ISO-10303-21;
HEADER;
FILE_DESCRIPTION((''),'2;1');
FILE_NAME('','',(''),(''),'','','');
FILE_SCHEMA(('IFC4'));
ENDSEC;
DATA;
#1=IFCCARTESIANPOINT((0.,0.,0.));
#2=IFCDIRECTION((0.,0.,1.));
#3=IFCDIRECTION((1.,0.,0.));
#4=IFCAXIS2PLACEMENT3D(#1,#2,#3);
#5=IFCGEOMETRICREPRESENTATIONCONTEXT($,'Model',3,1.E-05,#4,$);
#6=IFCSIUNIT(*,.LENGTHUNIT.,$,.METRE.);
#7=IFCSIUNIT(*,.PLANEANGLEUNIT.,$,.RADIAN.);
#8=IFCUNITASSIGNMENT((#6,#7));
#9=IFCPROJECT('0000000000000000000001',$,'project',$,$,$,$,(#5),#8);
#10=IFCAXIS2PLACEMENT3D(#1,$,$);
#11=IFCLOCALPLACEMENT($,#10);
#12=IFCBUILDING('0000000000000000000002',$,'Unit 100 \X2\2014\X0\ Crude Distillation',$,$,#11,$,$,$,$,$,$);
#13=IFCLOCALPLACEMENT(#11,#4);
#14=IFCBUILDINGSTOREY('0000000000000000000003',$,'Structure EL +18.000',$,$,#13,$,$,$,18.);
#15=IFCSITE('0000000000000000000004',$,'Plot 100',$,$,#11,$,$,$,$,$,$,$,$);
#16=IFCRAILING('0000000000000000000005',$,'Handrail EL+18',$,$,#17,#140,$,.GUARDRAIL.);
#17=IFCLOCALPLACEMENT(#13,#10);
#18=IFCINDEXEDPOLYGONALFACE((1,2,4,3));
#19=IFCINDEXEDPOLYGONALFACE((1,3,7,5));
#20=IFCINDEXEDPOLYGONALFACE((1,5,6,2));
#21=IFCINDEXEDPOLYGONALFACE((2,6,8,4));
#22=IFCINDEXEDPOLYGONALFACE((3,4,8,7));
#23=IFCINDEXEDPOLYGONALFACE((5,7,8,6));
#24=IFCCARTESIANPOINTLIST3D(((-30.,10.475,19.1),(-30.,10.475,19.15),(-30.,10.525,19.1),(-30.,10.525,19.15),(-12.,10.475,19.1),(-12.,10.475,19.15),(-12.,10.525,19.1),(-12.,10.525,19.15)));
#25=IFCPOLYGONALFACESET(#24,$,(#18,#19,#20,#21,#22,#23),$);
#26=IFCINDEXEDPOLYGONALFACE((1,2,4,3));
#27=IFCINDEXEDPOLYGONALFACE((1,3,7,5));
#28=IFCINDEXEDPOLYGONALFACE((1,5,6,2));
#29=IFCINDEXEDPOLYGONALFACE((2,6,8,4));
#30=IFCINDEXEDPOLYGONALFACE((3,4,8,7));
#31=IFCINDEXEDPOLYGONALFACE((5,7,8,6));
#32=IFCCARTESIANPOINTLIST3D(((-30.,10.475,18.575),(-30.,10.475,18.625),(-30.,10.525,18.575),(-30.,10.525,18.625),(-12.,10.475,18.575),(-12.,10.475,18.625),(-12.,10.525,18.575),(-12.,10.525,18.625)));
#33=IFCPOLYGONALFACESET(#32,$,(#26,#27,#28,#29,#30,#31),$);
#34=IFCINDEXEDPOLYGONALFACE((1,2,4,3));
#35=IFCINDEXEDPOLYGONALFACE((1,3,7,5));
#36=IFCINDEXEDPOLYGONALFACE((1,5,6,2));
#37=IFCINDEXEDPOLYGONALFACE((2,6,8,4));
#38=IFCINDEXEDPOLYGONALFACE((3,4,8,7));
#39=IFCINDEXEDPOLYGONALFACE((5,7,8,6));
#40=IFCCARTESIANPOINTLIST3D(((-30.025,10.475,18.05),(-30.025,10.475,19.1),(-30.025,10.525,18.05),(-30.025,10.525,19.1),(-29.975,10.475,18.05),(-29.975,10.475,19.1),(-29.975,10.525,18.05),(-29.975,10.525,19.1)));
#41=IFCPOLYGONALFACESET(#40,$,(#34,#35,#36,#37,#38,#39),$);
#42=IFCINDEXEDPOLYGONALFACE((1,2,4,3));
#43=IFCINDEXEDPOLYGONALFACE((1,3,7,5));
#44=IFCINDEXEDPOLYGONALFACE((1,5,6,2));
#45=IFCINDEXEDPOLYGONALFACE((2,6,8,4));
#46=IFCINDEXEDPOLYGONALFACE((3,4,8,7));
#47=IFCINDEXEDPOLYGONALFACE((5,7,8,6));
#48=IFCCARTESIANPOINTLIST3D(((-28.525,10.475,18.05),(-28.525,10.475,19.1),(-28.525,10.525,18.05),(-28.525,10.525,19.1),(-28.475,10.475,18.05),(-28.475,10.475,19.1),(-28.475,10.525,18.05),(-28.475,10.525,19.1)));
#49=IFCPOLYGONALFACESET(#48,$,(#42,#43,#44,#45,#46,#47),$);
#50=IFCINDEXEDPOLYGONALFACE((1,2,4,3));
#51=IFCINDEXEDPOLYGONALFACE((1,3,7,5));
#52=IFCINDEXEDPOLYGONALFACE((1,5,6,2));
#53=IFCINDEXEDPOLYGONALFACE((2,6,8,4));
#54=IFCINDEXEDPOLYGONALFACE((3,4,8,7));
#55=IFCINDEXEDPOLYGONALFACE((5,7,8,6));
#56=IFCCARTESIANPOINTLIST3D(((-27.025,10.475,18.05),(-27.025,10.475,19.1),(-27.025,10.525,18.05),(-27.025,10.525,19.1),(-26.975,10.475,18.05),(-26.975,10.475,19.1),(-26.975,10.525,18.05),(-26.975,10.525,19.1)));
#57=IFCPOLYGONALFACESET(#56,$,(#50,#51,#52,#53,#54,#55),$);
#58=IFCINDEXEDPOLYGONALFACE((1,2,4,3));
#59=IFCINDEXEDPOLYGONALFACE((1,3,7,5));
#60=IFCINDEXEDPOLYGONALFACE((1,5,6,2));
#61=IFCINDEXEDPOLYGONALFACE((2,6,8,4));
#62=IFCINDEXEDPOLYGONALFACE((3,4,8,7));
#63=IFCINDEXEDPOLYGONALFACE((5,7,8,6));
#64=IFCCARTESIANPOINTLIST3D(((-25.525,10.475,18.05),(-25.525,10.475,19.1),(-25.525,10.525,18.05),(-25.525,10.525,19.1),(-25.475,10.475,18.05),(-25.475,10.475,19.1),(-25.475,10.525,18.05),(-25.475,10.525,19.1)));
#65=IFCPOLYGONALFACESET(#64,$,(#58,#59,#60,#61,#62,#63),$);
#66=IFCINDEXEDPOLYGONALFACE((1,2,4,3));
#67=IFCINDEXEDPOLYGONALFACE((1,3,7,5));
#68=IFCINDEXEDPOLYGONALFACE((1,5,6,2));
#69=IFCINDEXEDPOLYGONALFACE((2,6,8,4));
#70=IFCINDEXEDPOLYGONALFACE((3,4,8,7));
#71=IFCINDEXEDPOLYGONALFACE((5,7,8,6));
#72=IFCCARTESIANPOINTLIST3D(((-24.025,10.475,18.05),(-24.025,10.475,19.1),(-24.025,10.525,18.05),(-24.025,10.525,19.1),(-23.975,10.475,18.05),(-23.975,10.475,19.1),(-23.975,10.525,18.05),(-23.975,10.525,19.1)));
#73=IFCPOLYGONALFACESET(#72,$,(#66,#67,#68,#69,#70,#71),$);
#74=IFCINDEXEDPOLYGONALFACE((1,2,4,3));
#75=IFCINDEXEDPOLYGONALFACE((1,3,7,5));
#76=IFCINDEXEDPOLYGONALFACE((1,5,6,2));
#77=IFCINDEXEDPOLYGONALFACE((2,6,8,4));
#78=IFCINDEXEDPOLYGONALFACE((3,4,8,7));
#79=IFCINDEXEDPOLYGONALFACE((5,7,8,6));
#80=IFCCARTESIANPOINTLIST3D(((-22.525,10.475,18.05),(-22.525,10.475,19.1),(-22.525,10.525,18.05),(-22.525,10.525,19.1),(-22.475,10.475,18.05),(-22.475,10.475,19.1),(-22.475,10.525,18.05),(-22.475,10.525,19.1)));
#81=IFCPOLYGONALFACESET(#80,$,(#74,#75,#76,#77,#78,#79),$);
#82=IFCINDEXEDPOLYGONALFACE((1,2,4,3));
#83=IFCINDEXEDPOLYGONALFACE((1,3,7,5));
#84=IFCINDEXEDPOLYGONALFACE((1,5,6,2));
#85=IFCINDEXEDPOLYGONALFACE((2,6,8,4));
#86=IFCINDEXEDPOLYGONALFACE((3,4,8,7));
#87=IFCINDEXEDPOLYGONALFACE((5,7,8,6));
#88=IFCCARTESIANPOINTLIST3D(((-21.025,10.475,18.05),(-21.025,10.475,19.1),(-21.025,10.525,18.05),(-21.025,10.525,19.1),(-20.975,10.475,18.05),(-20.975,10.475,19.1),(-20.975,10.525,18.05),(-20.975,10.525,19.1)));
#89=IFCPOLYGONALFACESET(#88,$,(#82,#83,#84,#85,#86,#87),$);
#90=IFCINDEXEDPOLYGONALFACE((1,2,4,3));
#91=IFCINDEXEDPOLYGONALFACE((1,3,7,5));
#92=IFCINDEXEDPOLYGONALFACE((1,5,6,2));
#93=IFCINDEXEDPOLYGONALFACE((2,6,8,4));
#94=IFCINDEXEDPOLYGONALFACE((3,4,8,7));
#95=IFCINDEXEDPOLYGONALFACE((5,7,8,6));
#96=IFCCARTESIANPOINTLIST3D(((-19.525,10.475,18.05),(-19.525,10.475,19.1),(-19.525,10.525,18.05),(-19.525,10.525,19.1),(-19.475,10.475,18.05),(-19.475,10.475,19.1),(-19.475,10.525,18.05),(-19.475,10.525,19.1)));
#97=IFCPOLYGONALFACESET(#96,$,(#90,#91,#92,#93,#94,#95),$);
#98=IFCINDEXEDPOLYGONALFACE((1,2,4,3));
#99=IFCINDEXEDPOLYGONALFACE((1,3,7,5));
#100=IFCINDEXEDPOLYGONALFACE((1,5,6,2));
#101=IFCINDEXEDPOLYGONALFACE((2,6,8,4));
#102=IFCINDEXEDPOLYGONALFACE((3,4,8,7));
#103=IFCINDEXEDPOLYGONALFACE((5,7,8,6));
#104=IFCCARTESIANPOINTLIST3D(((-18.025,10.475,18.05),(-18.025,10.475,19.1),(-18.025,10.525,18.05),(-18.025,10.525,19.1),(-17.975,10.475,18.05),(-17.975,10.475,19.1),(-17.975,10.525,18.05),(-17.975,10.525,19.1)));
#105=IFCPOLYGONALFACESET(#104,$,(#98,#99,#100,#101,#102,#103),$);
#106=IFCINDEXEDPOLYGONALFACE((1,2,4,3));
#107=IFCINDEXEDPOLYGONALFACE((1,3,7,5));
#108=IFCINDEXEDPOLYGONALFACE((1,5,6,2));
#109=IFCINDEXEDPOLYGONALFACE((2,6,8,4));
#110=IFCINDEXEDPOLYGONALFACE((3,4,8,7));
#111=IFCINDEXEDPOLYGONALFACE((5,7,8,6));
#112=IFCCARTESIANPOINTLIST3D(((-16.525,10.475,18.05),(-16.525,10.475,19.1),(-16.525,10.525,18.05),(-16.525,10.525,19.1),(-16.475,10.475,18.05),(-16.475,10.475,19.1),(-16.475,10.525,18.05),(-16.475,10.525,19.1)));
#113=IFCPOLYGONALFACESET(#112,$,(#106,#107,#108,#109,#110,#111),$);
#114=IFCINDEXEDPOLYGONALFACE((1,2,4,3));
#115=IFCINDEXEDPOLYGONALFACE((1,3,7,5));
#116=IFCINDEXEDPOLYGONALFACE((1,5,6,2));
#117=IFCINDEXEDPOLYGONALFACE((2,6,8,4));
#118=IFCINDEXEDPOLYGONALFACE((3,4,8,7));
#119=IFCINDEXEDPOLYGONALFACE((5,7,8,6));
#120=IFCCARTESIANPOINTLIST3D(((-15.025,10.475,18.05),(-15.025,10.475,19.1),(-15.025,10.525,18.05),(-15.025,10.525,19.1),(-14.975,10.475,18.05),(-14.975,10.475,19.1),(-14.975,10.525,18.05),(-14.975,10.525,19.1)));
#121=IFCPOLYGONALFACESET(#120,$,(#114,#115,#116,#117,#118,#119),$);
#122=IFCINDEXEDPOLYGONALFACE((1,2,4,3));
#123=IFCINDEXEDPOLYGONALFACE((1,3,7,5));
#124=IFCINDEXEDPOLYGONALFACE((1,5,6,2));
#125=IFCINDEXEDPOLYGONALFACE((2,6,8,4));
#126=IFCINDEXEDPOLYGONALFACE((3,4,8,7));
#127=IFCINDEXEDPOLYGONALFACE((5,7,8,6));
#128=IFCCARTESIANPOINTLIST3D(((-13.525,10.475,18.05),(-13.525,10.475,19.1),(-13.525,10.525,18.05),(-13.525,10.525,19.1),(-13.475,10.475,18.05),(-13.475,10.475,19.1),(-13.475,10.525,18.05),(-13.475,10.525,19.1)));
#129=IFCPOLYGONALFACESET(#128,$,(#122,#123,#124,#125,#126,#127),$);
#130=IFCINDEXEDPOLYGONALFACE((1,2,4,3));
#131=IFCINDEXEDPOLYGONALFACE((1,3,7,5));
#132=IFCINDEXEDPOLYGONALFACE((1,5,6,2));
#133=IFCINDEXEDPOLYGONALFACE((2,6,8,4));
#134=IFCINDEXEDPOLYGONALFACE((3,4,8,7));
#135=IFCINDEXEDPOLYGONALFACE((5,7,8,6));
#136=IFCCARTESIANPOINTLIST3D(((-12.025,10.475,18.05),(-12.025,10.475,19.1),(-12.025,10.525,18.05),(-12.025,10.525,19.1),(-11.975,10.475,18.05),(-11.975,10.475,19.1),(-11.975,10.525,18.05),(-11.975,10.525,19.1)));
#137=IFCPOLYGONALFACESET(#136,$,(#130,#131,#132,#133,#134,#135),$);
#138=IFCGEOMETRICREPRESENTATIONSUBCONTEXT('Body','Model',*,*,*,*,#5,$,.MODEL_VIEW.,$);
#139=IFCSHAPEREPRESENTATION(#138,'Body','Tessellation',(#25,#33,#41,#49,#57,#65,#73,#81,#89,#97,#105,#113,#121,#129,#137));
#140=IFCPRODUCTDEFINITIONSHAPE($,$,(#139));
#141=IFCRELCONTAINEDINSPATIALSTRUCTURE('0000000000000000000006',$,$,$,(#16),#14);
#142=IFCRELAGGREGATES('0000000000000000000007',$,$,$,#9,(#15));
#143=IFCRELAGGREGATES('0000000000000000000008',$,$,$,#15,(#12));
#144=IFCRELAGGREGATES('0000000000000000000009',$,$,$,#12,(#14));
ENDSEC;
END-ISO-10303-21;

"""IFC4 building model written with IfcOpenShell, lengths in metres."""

from ifc_helpers import new_model, si_unit, frame, origin, origin_with_axes, origin_2d, place, context, subcontext, project, spatial, rectangle, extrude, element, save


model = new_model("IFC4")

# Units and contexts
model_context = context("Model", 3, precision=1e-05, world=origin_with_axes())
body_context = subcontext(model_context, "Body", "Model", "MODEL_VIEW")
ifc_project = project(units=[si_unit("LENGTHUNIT", "METRE"), si_unit("PLANEANGLEUNIT", "RADIAN")], contexts=[model_context])

# Site, building, storey
placement = place(None, origin())
site = spatial("IfcSite", under=ifc_project, at=placement, Name="Plot 100")
building = spatial("IfcBuilding", under=site, at=placement, Name="Unit 100 — Crude Distillation")
storey_placement = place(placement, origin_with_axes())
storey = spatial("IfcBuildingStorey", under=building, at=storey_placement, Name="Structure EL +18.000", Elevation=18.0)

# Railing
railing_1_placement = place(storey_placement, origin_with_axes())
element("IfcRailing", 1, at=railing_1_placement, inside=storey, Name="Handrail EL+18", PredefinedType="GUARDRAIL", context=body_context, shape_type="SweptSolid", body=[
    extrude(rectangle(XDim=0.05, YDim=0.05, at=origin_2d()), frame((-30.0, 10.5, 19.125), z_axis=(1.0, 0.0, 0.0), x_axis=(0.0, 1.0, 0.0)), (0.0, 0.0, 1.0), 18.0),
    extrude(rectangle(XDim=0.05, YDim=0.05, at=origin_2d()), frame((-30.0, 10.5, 18.6), z_axis=(1.0, 0.0, 0.0), x_axis=(0.0, 1.0, 0.0)), (0.0, 0.0, 1.0), 18.0),
    extrude(rectangle(XDim=0.05, YDim=0.05, at=origin_2d()), frame((-30.0, 10.5, 18.05), z_axis=(0.0, 0.0, 1.0), x_axis=(1.0, 0.0, 0.0)), (0.0, 0.0, 1.0), 1.05),
    extrude(rectangle(XDim=0.05, YDim=0.05, at=origin_2d()), frame((-28.5, 10.5, 18.05), z_axis=(0.0, 0.0, 1.0), x_axis=(1.0, 0.0, 0.0)), (0.0, 0.0, 1.0), 1.05),
    extrude(rectangle(XDim=0.05, YDim=0.05, at=origin_2d()), frame((-27.0, 10.5, 18.05), z_axis=(0.0, 0.0, 1.0), x_axis=(1.0, 0.0, 0.0)), (0.0, 0.0, 1.0), 1.05),
    extrude(rectangle(XDim=0.05, YDim=0.05, at=origin_2d()), frame((-25.5, 10.5, 18.05), z_axis=(0.0, 0.0, 1.0), x_axis=(1.0, 0.0, 0.0)), (0.0, 0.0, 1.0), 1.05),
    extrude(rectangle(XDim=0.05, YDim=0.05, at=origin_2d()), frame((-24.0, 10.5, 18.05), z_axis=(0.0, 0.0, 1.0), x_axis=(1.0, 0.0, 0.0)), (0.0, 0.0, 1.0), 1.05),
    extrude(rectangle(XDim=0.05, YDim=0.05, at=origin_2d()), frame((-22.5, 10.5, 18.05), z_axis=(0.0, 0.0, 1.0), x_axis=(1.0, 0.0, 0.0)), (0.0, 0.0, 1.0), 1.05),
    extrude(rectangle(XDim=0.05, YDim=0.05, at=origin_2d()), frame((-21.0, 10.5, 18.05), z_axis=(0.0, 0.0, 1.0), x_axis=(1.0, 0.0, 0.0)), (0.0, 0.0, 1.0), 1.05),
    extrude(rectangle(XDim=0.05, YDim=0.05, at=origin_2d()), frame((-19.5, 10.5, 18.05), z_axis=(0.0, 0.0, 1.0), x_axis=(1.0, 0.0, 0.0)), (0.0, 0.0, 1.0), 1.05),
    extrude(rectangle(XDim=0.05, YDim=0.05, at=origin_2d()), frame((-18.0, 10.5, 18.05), z_axis=(0.0, 0.0, 1.0), x_axis=(1.0, 0.0, 0.0)), (0.0, 0.0, 1.0), 1.05),
    extrude(rectangle(XDim=0.05, YDim=0.05, at=origin_2d()), frame((-16.5, 10.5, 18.05), z_axis=(0.0, 0.0, 1.0), x_axis=(1.0, 0.0, 0.0)), (0.0, 0.0, 1.0), 1.05),
    extrude(rectangle(XDim=0.05, YDim=0.05, at=origin_2d()), frame((-15.0, 10.5, 18.05), z_axis=(0.0, 0.0, 1.0), x_axis=(1.0, 0.0, 0.0)), (0.0, 0.0, 1.0), 1.05),
    extrude(rectangle(XDim=0.05, YDim=0.05, at=origin_2d()), frame((-13.5, 10.5, 18.05), z_axis=(0.0, 0.0, 1.0), x_axis=(1.0, 0.0, 0.0)), (0.0, 0.0, 1.0), 1.05),
    extrude(rectangle(XDim=0.05, YDim=0.05, at=origin_2d()), frame((-12.0, 10.5, 18.05), z_axis=(0.0, 0.0, 1.0), x_axis=(1.0, 0.0, 0.0)), (0.0, 0.0, 1.0), 1.05),
])

save(model, "model.ifc")
